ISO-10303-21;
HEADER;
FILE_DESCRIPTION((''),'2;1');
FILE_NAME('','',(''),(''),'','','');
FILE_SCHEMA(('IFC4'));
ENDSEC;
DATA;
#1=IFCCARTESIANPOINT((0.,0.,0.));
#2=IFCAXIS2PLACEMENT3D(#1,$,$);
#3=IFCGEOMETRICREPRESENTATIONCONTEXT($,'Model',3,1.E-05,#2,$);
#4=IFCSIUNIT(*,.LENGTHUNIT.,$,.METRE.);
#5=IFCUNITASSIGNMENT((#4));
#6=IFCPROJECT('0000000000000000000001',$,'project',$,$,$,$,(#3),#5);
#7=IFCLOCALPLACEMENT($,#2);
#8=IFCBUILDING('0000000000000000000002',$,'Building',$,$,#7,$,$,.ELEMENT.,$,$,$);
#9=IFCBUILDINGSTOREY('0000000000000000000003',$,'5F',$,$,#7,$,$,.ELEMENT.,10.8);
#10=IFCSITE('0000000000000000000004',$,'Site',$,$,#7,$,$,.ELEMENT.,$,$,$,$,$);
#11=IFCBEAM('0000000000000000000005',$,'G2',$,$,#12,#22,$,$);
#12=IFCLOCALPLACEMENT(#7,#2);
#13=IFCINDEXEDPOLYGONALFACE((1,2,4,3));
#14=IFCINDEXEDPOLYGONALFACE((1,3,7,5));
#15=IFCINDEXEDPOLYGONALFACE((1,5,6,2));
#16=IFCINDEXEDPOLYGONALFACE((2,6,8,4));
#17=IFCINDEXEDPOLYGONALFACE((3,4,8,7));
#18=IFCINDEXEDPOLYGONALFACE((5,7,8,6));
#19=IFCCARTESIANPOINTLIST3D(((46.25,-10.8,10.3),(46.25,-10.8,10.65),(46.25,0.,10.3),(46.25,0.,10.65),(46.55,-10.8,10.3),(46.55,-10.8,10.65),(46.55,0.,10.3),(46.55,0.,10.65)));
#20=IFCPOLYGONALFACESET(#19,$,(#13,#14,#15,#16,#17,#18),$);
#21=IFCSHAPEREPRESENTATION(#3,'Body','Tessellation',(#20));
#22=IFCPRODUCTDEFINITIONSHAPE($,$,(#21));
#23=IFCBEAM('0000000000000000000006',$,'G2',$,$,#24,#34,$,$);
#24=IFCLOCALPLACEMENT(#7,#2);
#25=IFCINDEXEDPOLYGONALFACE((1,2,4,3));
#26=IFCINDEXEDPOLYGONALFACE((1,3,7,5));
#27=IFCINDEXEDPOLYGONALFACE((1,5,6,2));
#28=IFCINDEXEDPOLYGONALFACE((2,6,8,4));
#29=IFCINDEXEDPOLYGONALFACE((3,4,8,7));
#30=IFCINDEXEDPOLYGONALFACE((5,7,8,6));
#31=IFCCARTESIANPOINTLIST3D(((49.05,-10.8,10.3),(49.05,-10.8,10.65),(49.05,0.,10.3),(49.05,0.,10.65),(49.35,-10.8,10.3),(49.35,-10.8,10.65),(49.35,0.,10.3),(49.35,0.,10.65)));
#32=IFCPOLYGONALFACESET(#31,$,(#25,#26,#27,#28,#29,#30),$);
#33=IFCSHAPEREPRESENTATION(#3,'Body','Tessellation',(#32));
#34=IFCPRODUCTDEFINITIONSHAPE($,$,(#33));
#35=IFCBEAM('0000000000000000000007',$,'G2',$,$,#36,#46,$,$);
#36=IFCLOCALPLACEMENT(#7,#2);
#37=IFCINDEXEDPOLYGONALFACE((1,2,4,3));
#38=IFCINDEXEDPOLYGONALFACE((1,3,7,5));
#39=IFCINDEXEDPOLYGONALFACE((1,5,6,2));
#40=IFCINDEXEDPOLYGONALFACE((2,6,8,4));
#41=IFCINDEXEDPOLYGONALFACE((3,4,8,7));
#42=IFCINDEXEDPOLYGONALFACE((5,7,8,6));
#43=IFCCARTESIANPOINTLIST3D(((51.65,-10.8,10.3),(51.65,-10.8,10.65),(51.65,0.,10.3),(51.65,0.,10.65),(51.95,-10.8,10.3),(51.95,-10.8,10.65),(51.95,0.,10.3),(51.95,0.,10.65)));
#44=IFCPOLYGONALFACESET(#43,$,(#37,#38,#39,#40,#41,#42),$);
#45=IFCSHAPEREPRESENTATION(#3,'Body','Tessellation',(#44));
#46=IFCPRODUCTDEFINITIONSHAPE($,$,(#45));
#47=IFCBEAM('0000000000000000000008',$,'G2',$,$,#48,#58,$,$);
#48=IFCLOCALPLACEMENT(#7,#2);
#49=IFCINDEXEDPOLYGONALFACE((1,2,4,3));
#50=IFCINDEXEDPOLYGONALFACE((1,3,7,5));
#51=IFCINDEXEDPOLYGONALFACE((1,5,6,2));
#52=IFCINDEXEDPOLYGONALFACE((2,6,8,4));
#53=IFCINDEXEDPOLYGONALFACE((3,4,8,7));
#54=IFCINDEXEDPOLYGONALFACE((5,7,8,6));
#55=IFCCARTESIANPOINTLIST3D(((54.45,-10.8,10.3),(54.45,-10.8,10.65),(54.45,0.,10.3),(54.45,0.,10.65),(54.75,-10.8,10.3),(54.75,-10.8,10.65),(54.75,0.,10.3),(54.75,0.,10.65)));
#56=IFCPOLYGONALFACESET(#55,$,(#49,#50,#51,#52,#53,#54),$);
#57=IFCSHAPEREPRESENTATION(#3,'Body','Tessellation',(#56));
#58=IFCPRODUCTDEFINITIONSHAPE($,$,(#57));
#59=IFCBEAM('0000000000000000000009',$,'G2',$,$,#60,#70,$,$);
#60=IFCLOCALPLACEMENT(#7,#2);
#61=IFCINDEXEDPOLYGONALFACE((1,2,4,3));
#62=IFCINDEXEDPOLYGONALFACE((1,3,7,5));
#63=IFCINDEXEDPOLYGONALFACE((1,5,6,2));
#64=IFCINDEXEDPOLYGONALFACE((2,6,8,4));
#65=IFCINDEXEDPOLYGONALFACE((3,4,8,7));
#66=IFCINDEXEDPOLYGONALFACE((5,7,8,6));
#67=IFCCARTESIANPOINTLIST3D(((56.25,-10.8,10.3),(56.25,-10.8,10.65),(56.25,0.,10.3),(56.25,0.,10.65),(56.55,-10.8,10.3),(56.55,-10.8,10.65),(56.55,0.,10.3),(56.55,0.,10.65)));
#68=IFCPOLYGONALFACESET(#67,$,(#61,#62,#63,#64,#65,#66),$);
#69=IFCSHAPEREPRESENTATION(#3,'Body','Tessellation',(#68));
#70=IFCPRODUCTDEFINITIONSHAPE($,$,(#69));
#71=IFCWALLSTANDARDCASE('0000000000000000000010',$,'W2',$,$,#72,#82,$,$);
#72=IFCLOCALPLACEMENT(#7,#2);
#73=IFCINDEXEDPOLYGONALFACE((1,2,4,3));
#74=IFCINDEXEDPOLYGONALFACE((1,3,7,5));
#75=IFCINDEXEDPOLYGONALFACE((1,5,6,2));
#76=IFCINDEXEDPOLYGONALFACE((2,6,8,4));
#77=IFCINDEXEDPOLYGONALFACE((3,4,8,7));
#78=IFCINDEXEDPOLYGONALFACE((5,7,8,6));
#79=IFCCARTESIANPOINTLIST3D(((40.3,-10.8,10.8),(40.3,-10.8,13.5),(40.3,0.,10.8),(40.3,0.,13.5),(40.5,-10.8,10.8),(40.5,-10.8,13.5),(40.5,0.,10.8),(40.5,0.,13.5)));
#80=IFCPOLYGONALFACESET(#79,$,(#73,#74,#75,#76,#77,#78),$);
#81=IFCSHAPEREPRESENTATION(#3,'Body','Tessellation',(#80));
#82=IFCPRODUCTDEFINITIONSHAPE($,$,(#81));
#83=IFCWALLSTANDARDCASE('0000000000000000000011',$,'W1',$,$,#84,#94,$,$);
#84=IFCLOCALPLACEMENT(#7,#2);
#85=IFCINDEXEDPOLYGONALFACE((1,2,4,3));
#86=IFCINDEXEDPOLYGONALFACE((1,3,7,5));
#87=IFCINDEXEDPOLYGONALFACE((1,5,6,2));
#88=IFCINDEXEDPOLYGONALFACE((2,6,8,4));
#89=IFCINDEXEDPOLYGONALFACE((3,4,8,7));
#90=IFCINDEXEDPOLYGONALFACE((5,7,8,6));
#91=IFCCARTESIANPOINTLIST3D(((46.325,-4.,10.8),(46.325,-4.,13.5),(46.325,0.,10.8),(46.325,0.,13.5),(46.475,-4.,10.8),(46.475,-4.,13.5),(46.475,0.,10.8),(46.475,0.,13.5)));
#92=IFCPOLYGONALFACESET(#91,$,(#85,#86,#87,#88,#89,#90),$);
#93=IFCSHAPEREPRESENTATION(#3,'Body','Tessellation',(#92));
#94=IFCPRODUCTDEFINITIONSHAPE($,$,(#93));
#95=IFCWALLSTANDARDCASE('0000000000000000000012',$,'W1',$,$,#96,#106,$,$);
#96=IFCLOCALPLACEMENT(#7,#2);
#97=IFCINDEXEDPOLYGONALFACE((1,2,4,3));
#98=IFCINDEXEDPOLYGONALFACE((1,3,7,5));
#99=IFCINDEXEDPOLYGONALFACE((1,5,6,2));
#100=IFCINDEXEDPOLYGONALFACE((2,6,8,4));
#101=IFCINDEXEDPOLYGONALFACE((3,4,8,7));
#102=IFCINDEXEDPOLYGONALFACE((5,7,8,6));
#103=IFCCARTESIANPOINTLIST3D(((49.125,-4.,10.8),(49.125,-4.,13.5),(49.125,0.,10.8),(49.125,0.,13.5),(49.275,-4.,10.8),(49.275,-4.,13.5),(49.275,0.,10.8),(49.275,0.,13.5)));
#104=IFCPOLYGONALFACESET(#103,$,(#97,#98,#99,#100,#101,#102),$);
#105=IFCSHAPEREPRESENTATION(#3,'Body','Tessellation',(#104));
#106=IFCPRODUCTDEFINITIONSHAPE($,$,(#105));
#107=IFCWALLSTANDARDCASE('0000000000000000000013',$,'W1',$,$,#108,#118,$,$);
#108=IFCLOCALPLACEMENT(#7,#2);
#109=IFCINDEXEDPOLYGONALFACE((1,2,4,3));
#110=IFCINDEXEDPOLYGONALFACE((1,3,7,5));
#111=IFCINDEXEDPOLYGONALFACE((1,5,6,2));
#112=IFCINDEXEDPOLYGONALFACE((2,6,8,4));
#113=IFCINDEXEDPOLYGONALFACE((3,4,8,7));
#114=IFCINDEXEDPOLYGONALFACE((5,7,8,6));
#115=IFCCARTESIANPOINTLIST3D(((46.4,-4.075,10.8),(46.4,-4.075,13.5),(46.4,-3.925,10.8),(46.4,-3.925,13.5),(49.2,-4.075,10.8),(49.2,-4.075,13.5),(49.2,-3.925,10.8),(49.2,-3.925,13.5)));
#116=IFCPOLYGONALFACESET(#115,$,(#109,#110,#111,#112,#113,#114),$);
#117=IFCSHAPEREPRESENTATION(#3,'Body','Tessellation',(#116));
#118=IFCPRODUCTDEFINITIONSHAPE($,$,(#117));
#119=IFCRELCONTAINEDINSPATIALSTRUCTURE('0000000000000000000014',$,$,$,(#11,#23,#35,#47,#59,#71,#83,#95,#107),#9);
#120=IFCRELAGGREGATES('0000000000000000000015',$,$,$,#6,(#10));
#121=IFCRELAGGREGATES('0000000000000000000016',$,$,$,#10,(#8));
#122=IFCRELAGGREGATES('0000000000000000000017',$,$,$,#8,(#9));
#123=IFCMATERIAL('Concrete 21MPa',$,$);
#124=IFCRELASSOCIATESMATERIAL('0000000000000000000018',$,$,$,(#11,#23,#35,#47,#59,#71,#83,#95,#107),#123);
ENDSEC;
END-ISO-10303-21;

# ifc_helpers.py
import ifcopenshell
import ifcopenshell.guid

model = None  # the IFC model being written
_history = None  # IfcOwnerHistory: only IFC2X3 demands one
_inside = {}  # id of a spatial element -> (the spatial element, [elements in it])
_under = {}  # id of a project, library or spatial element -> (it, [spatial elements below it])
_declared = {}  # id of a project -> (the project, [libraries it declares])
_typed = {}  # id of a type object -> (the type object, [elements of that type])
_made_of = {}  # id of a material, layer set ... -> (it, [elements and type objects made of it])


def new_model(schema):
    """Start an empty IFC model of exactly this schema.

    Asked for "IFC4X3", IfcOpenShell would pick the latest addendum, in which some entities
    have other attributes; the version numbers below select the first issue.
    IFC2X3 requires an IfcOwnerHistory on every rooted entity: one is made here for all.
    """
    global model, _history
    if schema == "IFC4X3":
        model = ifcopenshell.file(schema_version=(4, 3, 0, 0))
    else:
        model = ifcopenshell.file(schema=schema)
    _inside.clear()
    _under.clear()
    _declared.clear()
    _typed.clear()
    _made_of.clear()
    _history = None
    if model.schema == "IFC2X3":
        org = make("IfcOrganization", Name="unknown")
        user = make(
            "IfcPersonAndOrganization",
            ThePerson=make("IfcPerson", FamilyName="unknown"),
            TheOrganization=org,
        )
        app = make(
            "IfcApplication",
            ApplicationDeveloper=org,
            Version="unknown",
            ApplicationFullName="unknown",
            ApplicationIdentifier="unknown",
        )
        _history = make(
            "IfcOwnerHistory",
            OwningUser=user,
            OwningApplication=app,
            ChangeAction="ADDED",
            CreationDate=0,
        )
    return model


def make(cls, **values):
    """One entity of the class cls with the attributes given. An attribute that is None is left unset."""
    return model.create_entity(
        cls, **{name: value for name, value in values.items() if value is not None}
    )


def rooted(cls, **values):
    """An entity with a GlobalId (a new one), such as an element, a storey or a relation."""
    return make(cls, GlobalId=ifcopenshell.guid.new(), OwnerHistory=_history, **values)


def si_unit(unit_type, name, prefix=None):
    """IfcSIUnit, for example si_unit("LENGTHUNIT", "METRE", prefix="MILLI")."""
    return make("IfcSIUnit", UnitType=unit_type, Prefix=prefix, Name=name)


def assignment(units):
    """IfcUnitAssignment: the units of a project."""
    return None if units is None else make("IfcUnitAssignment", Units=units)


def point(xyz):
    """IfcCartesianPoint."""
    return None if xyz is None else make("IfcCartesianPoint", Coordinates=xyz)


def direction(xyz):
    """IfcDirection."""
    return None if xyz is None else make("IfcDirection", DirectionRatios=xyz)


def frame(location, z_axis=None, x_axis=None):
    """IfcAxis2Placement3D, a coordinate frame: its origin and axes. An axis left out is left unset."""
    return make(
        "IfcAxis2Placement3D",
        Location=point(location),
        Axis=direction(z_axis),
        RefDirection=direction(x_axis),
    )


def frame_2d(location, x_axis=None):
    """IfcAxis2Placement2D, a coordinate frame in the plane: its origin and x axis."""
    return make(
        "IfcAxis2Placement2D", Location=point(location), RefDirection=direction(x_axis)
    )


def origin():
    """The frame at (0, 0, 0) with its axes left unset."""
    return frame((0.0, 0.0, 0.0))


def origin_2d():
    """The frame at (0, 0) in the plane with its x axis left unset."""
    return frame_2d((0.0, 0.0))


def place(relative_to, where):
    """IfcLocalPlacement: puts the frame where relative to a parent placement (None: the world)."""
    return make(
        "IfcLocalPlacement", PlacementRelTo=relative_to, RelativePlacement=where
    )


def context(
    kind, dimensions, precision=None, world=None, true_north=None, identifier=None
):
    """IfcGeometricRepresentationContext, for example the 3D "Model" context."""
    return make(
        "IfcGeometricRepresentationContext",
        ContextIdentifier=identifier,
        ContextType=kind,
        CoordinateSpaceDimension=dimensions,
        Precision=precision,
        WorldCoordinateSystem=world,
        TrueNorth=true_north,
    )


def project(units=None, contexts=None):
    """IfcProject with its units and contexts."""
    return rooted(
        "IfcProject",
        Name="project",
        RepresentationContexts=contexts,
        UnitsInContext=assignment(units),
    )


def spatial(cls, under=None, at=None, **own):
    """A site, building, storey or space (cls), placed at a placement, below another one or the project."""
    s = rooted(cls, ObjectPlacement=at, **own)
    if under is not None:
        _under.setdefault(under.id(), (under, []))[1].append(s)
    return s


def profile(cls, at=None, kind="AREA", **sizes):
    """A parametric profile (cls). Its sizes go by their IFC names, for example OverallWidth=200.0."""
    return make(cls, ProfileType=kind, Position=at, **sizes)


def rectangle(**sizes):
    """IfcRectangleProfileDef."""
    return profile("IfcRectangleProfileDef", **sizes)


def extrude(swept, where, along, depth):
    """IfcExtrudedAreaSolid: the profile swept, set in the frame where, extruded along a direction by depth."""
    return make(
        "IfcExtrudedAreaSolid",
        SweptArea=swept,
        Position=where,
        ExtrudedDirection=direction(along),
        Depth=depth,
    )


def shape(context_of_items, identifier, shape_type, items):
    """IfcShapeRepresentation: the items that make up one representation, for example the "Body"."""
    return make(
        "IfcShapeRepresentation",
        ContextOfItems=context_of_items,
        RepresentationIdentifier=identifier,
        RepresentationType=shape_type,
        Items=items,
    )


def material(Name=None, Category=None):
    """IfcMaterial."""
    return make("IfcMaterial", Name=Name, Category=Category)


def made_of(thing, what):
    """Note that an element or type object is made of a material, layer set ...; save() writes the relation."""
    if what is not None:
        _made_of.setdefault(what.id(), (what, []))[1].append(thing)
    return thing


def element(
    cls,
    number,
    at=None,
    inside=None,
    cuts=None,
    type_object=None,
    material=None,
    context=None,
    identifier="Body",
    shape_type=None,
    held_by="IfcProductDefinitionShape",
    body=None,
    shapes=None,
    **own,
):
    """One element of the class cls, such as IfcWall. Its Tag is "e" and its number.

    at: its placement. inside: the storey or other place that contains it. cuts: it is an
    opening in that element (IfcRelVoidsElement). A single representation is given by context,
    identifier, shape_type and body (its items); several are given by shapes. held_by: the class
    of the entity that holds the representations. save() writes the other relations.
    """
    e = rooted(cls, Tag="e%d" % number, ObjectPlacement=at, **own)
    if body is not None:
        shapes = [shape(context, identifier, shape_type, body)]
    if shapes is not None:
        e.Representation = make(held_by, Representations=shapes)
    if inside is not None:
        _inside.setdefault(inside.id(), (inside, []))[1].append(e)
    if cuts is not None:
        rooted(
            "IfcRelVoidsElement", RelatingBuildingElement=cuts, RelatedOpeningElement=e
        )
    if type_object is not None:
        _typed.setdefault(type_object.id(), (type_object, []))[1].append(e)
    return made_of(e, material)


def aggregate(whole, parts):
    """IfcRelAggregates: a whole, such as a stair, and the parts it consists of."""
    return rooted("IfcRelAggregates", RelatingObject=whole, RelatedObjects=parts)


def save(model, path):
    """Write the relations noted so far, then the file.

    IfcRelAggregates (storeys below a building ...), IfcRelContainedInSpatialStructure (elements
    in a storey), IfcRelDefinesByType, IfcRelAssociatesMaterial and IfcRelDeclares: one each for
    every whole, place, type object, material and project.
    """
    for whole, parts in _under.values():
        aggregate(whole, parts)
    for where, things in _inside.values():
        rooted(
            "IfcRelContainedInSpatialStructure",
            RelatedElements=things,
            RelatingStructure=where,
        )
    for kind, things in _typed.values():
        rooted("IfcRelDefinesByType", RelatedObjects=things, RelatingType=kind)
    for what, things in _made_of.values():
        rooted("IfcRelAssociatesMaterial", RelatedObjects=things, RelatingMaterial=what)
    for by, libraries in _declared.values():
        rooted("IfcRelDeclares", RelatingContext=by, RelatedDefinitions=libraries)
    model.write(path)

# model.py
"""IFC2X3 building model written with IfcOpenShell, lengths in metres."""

from ifc_helpers import new_model, si_unit, frame, origin, origin_2d, place, context, project, spatial, rectangle, extrude, material, element, save


model = new_model("IFC2X3")

# Units and contexts
model_context = context("Model", 3, precision=1e-05, world=origin())
ifc_project = project(units=[si_unit("LENGTHUNIT", "METRE")], contexts=[model_context])

# Site, building, storey
placement = place(None, origin())
site = spatial("IfcSite", under=ifc_project, at=placement, Name="Site", CompositionType="ELEMENT")
building = spatial("IfcBuilding", under=site, at=placement, Name="Building", CompositionType="ELEMENT")
storey = spatial("IfcBuildingStorey", under=building, at=placement, Name="5F", CompositionType="ELEMENT", Elevation=10.8)

# Shared definitions
ifc_material = material(Name="Concrete 21MPa")

# Beams
for number, where, name in (
    (1, (46.4, -5.4, 10.3), "G2"),
    (2, (49.2, -5.4, 10.3), "G2"),
    (3, (51.8, -5.4, 10.3), "G2"),
    (4, (54.6, -5.4, 10.3), "G2"),
    (5, (56.4, -5.4, 10.3), "G2"),
):
    element("IfcBeam", number, at=place(None, frame(where)), inside=storey, material=ifc_material, Name=name, context=model_context, shape_type="SweptSolid", body=[
        extrude(rectangle(XDim=0.3, YDim=10.8, at=origin_2d()), origin(), (0.0, 0.0, 1.0), 0.35),
    ])

# Walls
wall_1_placement = place(None, frame((40.4, -5.4, 10.8)))
element("IfcWallStandardCase", 6, at=wall_1_placement, inside=storey, material=ifc_material, Name="W2", context=model_context, shape_type="SweptSolid", body=[
    extrude(rectangle(XDim=0.2, YDim=10.8, at=origin_2d()), origin(), (0.0, 0.0, 1.0), 2.7),
])
for number, where, name in (
    (7, (46.4, -2.0, 10.8), "W1"),
    (8, (49.2, -2.0, 10.8), "W1"),
):
    element("IfcWallStandardCase", number, at=place(None, frame(where)), inside=storey, material=ifc_material, Name=name, context=model_context, shape_type="SweptSolid", body=[
        extrude(rectangle(XDim=0.15, YDim=4.0, at=origin_2d()), origin(), (0.0, 0.0, 1.0), 2.7),
    ])
wall_2_placement = place(None, frame((47.8, -4.0, 10.8)))
element("IfcWallStandardCase", 9, at=wall_2_placement, inside=storey, material=ifc_material, Name="W1", context=model_context, shape_type="SweptSolid", body=[
    extrude(rectangle(XDim=2.8, YDim=0.15, at=origin_2d()), origin(), (0.0, 0.0, 1.0), 2.7),
])

save(model, "model.ifc")
